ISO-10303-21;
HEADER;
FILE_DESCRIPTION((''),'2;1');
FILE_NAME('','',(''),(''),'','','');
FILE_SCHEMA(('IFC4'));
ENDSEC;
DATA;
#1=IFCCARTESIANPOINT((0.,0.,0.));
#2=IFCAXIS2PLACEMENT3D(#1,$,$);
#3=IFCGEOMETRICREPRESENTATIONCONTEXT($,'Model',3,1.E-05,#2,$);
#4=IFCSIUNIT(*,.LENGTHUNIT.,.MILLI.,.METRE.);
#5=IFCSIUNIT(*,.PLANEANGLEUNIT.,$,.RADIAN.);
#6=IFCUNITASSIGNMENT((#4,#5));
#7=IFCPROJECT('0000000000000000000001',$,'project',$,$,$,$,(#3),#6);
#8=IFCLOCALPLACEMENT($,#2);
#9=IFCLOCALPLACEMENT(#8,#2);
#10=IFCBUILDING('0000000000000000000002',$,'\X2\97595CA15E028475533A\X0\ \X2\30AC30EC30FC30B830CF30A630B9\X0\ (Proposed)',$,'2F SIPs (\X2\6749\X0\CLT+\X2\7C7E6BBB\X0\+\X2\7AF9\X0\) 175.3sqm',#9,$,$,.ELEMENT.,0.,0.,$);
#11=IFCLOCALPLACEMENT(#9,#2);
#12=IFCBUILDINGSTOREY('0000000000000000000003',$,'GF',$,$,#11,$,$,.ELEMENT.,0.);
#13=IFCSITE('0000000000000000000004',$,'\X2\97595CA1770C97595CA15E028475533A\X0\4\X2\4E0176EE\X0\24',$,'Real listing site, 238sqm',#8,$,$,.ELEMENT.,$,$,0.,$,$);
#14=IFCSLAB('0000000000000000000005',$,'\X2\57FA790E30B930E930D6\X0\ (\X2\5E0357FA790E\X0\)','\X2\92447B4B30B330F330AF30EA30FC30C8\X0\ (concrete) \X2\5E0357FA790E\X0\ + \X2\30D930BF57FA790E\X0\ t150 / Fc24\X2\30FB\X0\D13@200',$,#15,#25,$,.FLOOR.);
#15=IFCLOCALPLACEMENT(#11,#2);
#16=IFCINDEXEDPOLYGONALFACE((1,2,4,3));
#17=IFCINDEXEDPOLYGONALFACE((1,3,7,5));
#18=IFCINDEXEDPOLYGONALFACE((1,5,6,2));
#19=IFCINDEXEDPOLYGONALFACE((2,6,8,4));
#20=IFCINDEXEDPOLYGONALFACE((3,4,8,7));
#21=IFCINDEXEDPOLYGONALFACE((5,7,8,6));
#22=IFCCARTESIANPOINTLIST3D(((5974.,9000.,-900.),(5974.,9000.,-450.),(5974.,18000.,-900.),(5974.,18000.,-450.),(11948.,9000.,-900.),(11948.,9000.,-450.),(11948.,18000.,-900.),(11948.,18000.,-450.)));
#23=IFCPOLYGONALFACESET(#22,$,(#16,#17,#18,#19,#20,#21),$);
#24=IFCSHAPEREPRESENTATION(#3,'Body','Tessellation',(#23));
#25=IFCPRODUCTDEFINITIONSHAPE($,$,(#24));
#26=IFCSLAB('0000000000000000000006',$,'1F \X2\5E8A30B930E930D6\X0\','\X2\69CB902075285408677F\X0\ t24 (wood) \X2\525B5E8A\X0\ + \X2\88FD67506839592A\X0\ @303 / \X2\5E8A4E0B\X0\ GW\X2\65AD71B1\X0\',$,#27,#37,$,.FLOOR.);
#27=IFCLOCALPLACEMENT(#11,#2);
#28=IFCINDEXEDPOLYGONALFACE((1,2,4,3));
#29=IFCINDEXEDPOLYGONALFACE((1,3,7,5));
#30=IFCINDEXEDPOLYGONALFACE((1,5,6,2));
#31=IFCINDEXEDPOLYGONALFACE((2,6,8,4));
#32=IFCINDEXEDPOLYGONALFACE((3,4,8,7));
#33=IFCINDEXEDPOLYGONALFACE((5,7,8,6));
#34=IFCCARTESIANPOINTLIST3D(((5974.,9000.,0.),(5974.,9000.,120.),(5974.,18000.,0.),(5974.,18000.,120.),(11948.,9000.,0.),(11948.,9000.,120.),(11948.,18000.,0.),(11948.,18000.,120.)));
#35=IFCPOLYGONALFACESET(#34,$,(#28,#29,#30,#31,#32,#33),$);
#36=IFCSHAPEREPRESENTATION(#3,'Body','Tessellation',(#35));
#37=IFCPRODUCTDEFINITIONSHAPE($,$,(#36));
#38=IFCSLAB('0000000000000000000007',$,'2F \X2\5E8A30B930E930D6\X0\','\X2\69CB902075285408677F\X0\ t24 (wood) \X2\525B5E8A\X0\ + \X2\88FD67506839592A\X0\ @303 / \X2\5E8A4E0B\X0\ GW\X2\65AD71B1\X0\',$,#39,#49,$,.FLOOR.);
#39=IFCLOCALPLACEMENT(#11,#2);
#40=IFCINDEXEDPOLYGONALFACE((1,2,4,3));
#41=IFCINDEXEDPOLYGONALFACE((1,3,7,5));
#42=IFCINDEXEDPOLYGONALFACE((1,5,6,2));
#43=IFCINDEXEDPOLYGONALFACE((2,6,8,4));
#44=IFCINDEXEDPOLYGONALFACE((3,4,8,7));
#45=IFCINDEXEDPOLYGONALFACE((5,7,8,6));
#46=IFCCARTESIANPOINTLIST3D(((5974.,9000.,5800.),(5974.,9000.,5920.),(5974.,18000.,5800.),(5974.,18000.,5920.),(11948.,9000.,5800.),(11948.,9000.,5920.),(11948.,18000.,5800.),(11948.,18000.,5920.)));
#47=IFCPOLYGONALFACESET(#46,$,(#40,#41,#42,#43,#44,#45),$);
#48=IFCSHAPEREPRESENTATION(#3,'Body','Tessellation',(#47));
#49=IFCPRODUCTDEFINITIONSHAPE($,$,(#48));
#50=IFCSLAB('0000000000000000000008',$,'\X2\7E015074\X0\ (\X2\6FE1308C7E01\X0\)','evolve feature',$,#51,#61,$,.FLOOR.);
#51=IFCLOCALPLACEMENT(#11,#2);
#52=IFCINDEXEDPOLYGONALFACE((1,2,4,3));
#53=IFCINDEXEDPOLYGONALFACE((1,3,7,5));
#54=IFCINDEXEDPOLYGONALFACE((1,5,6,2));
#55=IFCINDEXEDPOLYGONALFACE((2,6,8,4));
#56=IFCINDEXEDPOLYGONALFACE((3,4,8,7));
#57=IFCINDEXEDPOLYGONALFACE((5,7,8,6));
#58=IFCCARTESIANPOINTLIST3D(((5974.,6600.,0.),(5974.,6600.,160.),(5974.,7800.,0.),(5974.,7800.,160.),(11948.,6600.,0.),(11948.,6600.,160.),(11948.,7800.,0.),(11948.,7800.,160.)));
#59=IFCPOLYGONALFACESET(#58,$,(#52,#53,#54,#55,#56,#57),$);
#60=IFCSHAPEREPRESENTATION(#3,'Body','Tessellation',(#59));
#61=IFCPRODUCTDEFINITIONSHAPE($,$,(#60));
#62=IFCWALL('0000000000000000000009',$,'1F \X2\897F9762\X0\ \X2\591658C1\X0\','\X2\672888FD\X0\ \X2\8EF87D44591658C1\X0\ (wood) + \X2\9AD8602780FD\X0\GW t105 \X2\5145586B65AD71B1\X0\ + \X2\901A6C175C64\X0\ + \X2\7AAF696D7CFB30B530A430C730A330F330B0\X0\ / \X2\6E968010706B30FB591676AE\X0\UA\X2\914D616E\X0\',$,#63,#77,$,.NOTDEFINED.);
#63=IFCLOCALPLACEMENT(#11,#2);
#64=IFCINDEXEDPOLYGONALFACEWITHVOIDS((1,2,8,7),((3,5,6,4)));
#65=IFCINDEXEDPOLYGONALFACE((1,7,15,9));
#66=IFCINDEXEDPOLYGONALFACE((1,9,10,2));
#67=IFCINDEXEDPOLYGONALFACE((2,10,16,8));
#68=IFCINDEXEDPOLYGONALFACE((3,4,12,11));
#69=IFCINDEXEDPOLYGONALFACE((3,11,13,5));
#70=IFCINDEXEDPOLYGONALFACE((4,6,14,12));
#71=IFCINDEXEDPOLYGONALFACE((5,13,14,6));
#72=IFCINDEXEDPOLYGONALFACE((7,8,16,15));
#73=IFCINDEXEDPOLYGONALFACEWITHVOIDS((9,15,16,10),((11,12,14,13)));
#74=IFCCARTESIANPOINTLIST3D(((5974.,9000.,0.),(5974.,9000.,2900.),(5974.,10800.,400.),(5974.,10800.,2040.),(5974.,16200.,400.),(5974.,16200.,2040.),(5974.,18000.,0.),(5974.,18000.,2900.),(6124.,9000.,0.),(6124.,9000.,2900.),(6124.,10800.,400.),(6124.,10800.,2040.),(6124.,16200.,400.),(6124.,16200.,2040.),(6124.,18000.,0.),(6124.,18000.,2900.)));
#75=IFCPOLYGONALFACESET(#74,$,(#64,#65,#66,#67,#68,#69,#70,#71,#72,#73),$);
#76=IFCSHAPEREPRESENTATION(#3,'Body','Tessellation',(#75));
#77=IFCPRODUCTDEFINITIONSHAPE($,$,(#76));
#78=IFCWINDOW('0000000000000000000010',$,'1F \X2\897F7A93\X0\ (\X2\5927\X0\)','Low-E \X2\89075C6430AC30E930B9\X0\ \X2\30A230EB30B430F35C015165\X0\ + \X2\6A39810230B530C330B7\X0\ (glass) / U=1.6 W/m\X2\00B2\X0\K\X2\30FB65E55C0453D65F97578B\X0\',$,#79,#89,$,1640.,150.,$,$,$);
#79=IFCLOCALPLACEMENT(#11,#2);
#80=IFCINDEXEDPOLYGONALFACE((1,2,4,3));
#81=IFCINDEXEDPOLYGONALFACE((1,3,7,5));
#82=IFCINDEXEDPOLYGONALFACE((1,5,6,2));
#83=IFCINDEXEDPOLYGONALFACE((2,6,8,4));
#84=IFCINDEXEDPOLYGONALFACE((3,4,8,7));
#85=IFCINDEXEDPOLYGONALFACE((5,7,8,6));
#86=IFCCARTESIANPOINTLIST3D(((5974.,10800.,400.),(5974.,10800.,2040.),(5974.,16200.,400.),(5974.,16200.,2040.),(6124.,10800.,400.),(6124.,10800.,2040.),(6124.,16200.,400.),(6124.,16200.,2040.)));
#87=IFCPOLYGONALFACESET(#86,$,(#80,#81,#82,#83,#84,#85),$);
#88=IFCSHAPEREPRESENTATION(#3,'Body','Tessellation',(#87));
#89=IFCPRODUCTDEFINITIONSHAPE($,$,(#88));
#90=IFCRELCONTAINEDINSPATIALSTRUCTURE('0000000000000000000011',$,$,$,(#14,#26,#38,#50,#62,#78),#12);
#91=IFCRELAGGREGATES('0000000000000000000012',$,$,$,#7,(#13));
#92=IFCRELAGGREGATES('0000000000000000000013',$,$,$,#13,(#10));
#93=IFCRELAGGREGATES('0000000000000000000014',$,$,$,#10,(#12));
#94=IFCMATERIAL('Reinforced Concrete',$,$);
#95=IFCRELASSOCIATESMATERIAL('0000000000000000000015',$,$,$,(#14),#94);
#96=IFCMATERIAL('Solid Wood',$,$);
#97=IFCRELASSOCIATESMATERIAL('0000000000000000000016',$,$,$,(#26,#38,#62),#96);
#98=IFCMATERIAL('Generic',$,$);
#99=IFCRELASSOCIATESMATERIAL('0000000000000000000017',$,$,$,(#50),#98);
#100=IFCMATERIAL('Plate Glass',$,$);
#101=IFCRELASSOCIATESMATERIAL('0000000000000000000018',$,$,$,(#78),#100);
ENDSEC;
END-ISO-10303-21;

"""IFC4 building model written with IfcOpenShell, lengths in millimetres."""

from ifc_helpers import new_model, si_unit, frame, frame_2d, origin, place, context, project, spatial, rectangle, extrude, material, element, fill, save


model = new_model("IFC4")

# Units and contexts
model_context = context("Model", 3, precision=1e-05, world=origin())
ifc_project = project(units=[si_unit("LENGTHUNIT", "METRE", prefix="MILLI"), si_unit("PLANEANGLEUNIT", "RADIAN")], contexts=[model_context])

# Site, building, storey
site_placement = place(None, origin())
site = spatial("IfcSite", under=ifc_project, at=site_placement, Name="静岡県静岡市葵区4丁目24", ObjectType="Real listing site, 238sqm", CompositionType="ELEMENT", RefElevation=0.0)
building_placement = place(site_placement, origin())
building = spatial("IfcBuilding", under=site, at=building_placement, Name="静岡市葵区 ガレージハウス (Proposed)", ObjectType="2F SIPs (杉CLT+籾殻+竹) 175.3sqm", CompositionType="ELEMENT", ElevationOfRefHeight=0.0, ElevationOfTerrain=0.0)
storey_placement = place(building_placement, origin())
storey = spatial("IfcBuildingStorey", under=building, at=storey_placement, Name="GF", CompositionType="ELEMENT", Elevation=0.0)

# Slabs
ifc_material_1 = material(Name="Reinforced Concrete")
slab_1_placement = place(storey_placement, frame((2987.0, 4500.0, -450.0)))
element("IfcSlab", 1, at=slab_1_placement, inside=storey, material=ifc_material_1, Name="基礎スラブ (布基礎)", Description="鉄筋コンクリート (concrete) 布基礎 + ベタ基礎 t150 / Fc24・D13@200", PredefinedType="FLOOR", context=model_context, shape_type="SweptSolid", body=[
    extrude(rectangle(XDim=5974.0, YDim=9000.0, at=frame_2d((2987.0, 4500.0))), frame((2987.0, 4500.0, -450.0)), (0.0, 0.0, 1.0), 450.0),
])
ifc_material_2 = material(Name="Solid Wood")
slab_2_placement = place(storey_placement, frame((2987.0, 4500.0, 0.0)))
element("IfcSlab", 2, at=slab_2_placement, inside=storey, material=ifc_material_2, Name="1F 床スラブ", Description="構造用合板 t24 (wood) 剛床 + 製材根太 @303 / 床下 GW断熱", PredefinedType="FLOOR", context=model_context, shape_type="SweptSolid", body=[
    extrude(rectangle(XDim=5974.0, YDim=9000.0, at=frame_2d((2987.0, 4500.0))), frame((2987.0, 4500.0, 0.0)), (0.0, 0.0, 1.0), 120.0),
])
slab_3_placement = place(storey_placement, frame((2987.0, 4500.0, 2900.0)))
element("IfcSlab", 3, at=slab_3_placement, inside=storey, material=ifc_material_2, Name="2F 床スラブ", Description="構造用合板 t24 (wood) 剛床 + 製材根太 @303 / 床下 GW断熱", PredefinedType="FLOOR", context=model_context, shape_type="SweptSolid", body=[
    extrude(rectangle(XDim=5974.0, YDim=9000.0, at=frame_2d((2987.0, 4500.0))), frame((2987.0, 4500.0, 2900.0)), (0.0, 0.0, 1.0), 120.0),
])
ifc_material_3 = material(Name="Generic")
slab_4_placement = place(storey_placement, frame((2987.0, 3300.0, 0.0)))
element("IfcSlab", 4, at=slab_4_placement, inside=storey, material=ifc_material_3, Name="縁側 (濡れ縁)", Description="evolve feature", PredefinedType="FLOOR", context=model_context, shape_type="SweptSolid", body=[
    extrude(rectangle(XDim=5974.0, YDim=1200.0, at=frame_2d((2987.0, 600.0))), frame((2987.0, 3300.0, 0.0)), (0.0, 0.0, 1.0), 160.0),
])

# Shared definitions
ifc_material_4 = material(Name="Plate Glass")

# Wall, opening, window
wall_1_placement = place(storey_placement, frame((2987.0, 4500.0, 0.0)))
wall_1 = element("IfcWall", 5, at=wall_1_placement, inside=storey, material=ifc_material_2, Name="1F 西面 外壁", Description="木製 軸組外壁 (wood) + 高性能GW t105 充填断熱 + 通気層 + 窯業系サイディング / 準耐火・外皮UA配慮", PredefinedType="NOTDEFINED", context=model_context, shape_type="SweptSolid", body=[
    extrude(rectangle(XDim=150.0, YDim=9000.0, at=frame_2d((75.0, 4500.0))), frame((2987.0, 4500.0, 0.0)), (0.0, 0.0, 1.0), 2900.0),
])
opening_1_placement = place(storey_placement, frame((2987.0, 5400.0, 200.0)))
opening_1 = element("IfcOpeningElement", 6, at=opening_1_placement, cuts=wall_1, PredefinedType="NOTDEFINED", context=model_context, shape_type="SweptSolid", body=[
    extrude(rectangle(XDim=150.0, YDim=5400.0, at=frame_2d((75.0, 2700.0))), frame((2987.0, 5400.0, 200.0)), (0.0, 0.0, 1.0), 1640.0),
])
window_1_placement = place(storey_placement, frame((2987.0, 5400.0, 200.0)))
window_1 = element("IfcWindow", 7, at=window_1_placement, inside=storey, material=ifc_material_4, Name="1F 西窓 (大)", Description="Low-E 複層ガラス アルゴン封入 + 樹脂サッシ (glass) / U=1.6 W/m²K・日射取得型", OverallHeight=1640.0, OverallWidth=150.0, context=model_context, shape_type="SweptSolid", body=[
    extrude(rectangle(XDim=150.0, YDim=5400.0, at=frame_2d((75.0, 2700.0))), frame((2987.0, 5400.0, 200.0)), (0.0, 0.0, 1.0), 1640.0),
])
fill(opening_1, window_1)

save(model, "model.ifc")
